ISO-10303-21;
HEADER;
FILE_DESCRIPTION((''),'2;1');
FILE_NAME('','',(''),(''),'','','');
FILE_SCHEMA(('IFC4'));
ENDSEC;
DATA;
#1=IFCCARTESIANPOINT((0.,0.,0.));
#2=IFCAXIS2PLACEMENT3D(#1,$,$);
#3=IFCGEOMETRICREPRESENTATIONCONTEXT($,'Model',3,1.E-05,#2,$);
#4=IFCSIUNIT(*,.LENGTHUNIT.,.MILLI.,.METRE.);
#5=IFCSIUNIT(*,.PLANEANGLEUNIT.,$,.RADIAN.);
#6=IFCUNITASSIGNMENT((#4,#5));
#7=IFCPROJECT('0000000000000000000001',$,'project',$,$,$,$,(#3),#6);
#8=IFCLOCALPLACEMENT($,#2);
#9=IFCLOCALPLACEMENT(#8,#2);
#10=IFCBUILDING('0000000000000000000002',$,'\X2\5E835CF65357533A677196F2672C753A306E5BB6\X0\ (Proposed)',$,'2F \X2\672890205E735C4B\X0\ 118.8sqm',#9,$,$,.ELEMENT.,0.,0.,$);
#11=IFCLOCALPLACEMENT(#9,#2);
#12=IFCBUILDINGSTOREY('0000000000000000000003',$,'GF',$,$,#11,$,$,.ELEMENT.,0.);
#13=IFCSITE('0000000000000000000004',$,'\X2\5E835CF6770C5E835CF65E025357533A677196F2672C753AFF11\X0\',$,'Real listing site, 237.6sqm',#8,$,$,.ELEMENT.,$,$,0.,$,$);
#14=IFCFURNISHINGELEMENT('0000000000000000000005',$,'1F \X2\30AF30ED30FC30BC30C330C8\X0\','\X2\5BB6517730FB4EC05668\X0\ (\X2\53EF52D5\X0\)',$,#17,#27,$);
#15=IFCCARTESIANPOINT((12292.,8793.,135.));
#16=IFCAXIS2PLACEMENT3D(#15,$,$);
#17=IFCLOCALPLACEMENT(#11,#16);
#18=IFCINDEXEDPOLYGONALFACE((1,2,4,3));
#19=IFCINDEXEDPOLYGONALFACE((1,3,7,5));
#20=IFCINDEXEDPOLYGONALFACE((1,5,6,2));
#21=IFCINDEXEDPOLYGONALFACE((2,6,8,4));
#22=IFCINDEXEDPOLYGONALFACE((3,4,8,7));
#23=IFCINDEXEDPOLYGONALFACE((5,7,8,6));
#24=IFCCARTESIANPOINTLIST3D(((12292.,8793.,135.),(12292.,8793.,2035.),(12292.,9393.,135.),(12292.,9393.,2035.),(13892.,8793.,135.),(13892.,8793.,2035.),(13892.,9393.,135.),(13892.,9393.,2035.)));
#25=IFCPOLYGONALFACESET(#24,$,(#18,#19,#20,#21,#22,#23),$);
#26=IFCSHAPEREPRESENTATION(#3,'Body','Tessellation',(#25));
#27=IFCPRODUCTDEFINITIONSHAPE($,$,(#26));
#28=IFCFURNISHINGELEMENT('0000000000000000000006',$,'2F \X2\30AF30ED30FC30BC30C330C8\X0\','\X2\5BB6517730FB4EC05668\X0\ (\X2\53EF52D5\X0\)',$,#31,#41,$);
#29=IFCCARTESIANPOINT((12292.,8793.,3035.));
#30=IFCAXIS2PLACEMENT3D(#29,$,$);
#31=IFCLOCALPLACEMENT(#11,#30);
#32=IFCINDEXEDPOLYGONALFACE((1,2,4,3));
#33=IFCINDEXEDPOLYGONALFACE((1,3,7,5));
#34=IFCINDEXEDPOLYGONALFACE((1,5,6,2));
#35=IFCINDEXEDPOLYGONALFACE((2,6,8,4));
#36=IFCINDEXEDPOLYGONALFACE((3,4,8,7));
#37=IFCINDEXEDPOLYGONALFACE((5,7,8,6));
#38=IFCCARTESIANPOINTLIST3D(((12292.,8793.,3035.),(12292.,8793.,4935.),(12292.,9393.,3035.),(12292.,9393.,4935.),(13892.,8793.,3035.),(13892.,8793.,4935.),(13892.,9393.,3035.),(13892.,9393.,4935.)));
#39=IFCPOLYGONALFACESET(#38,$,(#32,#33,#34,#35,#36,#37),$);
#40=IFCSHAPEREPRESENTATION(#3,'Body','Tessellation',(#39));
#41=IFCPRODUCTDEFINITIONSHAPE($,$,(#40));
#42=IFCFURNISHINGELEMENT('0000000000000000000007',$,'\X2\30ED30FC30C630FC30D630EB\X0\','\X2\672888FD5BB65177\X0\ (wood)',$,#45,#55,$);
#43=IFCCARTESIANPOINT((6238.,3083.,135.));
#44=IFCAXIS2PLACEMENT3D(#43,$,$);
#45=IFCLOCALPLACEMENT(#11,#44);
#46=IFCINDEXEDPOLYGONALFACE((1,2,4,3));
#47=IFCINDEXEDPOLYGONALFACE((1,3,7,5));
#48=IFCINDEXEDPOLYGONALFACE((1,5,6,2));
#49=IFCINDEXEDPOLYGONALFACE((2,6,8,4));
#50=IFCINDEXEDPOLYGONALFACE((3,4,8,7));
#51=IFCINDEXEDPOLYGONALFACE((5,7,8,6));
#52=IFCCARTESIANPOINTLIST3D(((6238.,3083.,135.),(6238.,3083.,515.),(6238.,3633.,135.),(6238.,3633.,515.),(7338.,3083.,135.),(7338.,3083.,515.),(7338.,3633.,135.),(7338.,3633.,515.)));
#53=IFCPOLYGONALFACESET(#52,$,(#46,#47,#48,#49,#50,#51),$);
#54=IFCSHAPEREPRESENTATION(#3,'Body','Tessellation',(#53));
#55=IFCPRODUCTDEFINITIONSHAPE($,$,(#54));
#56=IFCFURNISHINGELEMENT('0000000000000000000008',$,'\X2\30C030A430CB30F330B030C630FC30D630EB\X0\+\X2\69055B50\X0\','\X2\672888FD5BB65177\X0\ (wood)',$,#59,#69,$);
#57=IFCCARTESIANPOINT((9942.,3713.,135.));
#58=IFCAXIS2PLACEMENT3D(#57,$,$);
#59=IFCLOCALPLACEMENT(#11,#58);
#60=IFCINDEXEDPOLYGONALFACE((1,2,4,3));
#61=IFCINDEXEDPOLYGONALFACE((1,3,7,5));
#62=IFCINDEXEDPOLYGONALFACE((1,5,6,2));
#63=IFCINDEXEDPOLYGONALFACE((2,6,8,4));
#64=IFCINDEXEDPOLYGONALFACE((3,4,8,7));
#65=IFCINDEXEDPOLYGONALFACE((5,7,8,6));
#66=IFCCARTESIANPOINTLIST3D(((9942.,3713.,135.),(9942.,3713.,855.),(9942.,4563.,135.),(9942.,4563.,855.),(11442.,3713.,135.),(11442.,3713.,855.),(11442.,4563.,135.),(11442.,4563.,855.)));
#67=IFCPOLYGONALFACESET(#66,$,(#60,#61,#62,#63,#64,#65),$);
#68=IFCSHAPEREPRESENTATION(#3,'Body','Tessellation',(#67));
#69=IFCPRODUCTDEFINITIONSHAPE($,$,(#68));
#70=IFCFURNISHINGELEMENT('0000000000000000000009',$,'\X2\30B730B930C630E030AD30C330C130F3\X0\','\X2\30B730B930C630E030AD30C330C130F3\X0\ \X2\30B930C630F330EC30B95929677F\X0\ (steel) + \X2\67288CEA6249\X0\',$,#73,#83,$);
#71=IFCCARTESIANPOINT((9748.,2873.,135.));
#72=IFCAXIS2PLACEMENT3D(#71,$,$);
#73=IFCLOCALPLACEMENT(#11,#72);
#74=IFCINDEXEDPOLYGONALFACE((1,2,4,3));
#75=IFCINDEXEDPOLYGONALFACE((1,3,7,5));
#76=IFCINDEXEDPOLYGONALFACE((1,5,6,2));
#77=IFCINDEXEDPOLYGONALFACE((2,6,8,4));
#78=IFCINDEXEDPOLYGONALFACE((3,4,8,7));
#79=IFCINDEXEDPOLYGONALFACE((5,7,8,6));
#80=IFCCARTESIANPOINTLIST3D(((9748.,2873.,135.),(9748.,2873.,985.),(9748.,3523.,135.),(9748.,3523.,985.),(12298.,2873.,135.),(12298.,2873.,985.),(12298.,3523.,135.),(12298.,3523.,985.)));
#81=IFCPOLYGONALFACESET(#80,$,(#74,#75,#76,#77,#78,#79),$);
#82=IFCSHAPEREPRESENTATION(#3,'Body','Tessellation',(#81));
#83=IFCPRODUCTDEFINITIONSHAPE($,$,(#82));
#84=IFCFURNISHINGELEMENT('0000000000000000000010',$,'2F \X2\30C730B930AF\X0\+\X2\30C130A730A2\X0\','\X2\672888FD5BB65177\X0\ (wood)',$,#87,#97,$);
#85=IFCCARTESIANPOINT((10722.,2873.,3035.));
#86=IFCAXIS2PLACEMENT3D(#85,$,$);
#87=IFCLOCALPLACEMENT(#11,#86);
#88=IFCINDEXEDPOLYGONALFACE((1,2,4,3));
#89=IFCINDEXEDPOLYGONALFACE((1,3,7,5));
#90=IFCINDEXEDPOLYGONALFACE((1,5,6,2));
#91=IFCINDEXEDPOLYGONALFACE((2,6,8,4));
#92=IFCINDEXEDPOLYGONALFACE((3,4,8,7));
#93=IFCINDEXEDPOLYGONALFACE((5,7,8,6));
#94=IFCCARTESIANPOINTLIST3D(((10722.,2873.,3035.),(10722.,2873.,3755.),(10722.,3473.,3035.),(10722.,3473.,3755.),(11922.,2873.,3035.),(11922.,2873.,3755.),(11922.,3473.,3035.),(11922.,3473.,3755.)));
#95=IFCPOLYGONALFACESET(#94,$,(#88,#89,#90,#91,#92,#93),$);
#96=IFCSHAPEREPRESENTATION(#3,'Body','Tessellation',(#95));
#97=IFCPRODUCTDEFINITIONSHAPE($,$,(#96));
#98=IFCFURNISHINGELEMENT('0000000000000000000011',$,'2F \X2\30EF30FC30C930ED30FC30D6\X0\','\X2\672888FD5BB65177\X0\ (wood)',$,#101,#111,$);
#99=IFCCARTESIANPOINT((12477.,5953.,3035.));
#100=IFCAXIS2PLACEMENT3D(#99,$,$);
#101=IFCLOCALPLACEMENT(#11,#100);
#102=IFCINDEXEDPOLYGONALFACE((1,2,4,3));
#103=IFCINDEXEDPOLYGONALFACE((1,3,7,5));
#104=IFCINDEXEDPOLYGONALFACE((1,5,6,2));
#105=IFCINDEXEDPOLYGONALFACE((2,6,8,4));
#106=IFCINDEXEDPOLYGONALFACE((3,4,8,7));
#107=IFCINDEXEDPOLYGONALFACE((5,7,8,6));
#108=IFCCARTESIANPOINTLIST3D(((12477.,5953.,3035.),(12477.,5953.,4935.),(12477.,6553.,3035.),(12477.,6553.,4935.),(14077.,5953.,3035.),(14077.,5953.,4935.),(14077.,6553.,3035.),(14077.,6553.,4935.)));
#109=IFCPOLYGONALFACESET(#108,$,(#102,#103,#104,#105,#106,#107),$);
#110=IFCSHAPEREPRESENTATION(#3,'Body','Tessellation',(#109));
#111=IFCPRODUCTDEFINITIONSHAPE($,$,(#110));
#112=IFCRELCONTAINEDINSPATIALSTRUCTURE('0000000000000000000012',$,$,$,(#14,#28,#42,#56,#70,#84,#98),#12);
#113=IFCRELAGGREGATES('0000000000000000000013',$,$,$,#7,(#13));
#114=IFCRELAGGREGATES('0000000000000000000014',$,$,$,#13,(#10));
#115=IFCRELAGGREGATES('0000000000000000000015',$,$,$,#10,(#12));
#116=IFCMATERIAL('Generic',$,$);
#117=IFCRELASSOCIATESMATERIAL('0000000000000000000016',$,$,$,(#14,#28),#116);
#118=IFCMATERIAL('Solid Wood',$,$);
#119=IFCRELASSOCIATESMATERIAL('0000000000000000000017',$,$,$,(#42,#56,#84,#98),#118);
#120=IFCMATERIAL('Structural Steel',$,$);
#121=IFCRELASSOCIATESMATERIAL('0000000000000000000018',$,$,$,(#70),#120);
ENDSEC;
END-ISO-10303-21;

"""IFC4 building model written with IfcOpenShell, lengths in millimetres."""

from ifc_helpers import new_model, si_unit, frame, frame_2d, origin, place, context, project, spatial, rectangle, extrude, material, element, save


model = new_model("IFC4")

# Units and contexts
model_context = context("Model", 3, precision=1e-05, world=origin())
ifc_project = project(units=[si_unit("LENGTHUNIT", "METRE", prefix="MILLI"), si_unit("PLANEANGLEUNIT", "RADIAN")], contexts=[model_context])

# Site, building, storey
site_placement = place(None, origin())
site = spatial("IfcSite", under=ifc_project, at=site_placement, Name="広島県広島市南区東雲本町１", ObjectType="Real listing site, 237.6sqm", CompositionType="ELEMENT", RefElevation=0.0)
building_placement = place(site_placement, origin())
building = spatial("IfcBuilding", under=site, at=building_placement, Name="広島南区東雲本町の家 (Proposed)", ObjectType="2F 木造平屋 118.8sqm", CompositionType="ELEMENT", ElevationOfRefHeight=0.0, ElevationOfTerrain=0.0)
storey_placement = place(building_placement, origin())
storey = spatial("IfcBuildingStorey", under=building, at=storey_placement, Name="GF", CompositionType="ELEMENT", Elevation=0.0)

# Shared definitions
ifc_material_1 = material(Name="Solid Wood")

# Shared definitions
ifc_material_2 = material(Name="Generic")

# Furnishing elements
furnishing_1_placement = place(storey_placement, frame((12292.0, 8793.0, 135.0)))
element("IfcFurnishingElement", 1, at=furnishing_1_placement, inside=storey, material=ifc_material_2, Name="1F クローゼット", Description="家具・什器 (可動)", context=model_context, shape_type="SweptSolid", body=[
    extrude(rectangle(XDim=1600.0, YDim=600.0, at=frame_2d((800.0, 300.0))), frame((12292.0, 8793.0, 135.0)), (0.0, 0.0, 1.0), 1900.0),
])
furnishing_2_placement = place(storey_placement, frame((12292.0, 8793.0, 3035.0)))
element("IfcFurnishingElement", 2, at=furnishing_2_placement, inside=storey, material=ifc_material_2, Name="2F クローゼット", Description="家具・什器 (可動)", context=model_context, shape_type="SweptSolid", body=[
    extrude(rectangle(XDim=1600.0, YDim=600.0, at=frame_2d((800.0, 300.0))), frame((12292.0, 8793.0, 3035.0)), (0.0, 0.0, 1.0), 1900.0),
])
furnishing_3_placement = place(storey_placement, frame((6238.0, 3083.0, 135.0)))
element("IfcFurnishingElement", 3, at=furnishing_3_placement, inside=storey, material=ifc_material_1, Name="ローテーブル", Description="木製家具 (wood)", context=model_context, shape_type="SweptSolid", body=[
    extrude(rectangle(XDim=1100.0, YDim=550.0, at=frame_2d((550.0, 275.0))), frame((6238.0, 3083.0, 135.0)), (0.0, 0.0, 1.0), 380.0),
])
furnishing_4_placement = place(storey_placement, frame((9942.0, 3713.0, 135.0)))
element("IfcFurnishingElement", 4, at=furnishing_4_placement, inside=storey, material=ifc_material_1, Name="ダイニングテーブル+椅子", Description="木製家具 (wood)", context=model_context, shape_type="SweptSolid", body=[
    extrude(rectangle(XDim=1500.0, YDim=850.0, at=frame_2d((750.0, 425.0))), frame((9942.0, 3713.0, 135.0)), (0.0, 0.0, 1.0), 720.0),
])
ifc_material_3 = material(Name="Structural Steel")
furnishing_5_placement = place(storey_placement, frame((9748.0, 2873.0, 135.0)))
element("IfcFurnishingElement", 5, at=furnishing_5_placement, inside=storey, material=ifc_material_3, Name="システムキッチン", Description="システムキッチン ステンレス天板 (steel) + 木質扉", context=model_context, shape_type="SweptSolid", body=[
    extrude(rectangle(XDim=2550.0, YDim=650.0, at=frame_2d((1275.0, 325.0))), frame((9748.0, 2873.0, 135.0)), (0.0, 0.0, 1.0), 850.0),
])
furnishing_6_placement = place(storey_placement, frame((10722.0, 2873.0, 3035.0)))
element("IfcFurnishingElement", 6, at=furnishing_6_placement, inside=storey, material=ifc_material_1, Name="2F デスク+チェア", Description="木製家具 (wood)", context=model_context, shape_type="SweptSolid", body=[
    extrude(rectangle(XDim=1200.0, YDim=600.0, at=frame_2d((600.0, 300.0))), frame((10722.0, 2873.0, 3035.0)), (0.0, 0.0, 1.0), 720.0),
])
furnishing_7_placement = place(storey_placement, frame((12477.0, 5953.0, 3035.0)))
element("IfcFurnishingElement", 7, at=furnishing_7_placement, inside=storey, material=ifc_material_1, Name="2F ワードローブ", Description="木製家具 (wood)", context=model_context, shape_type="SweptSolid", body=[
    extrude(rectangle(XDim=1600.0, YDim=600.0, at=frame_2d((800.0, 300.0))), frame((12477.0, 5953.0, 3035.0)), (0.0, 0.0, 1.0), 1900.0),
])

save(model, "model.ifc")
